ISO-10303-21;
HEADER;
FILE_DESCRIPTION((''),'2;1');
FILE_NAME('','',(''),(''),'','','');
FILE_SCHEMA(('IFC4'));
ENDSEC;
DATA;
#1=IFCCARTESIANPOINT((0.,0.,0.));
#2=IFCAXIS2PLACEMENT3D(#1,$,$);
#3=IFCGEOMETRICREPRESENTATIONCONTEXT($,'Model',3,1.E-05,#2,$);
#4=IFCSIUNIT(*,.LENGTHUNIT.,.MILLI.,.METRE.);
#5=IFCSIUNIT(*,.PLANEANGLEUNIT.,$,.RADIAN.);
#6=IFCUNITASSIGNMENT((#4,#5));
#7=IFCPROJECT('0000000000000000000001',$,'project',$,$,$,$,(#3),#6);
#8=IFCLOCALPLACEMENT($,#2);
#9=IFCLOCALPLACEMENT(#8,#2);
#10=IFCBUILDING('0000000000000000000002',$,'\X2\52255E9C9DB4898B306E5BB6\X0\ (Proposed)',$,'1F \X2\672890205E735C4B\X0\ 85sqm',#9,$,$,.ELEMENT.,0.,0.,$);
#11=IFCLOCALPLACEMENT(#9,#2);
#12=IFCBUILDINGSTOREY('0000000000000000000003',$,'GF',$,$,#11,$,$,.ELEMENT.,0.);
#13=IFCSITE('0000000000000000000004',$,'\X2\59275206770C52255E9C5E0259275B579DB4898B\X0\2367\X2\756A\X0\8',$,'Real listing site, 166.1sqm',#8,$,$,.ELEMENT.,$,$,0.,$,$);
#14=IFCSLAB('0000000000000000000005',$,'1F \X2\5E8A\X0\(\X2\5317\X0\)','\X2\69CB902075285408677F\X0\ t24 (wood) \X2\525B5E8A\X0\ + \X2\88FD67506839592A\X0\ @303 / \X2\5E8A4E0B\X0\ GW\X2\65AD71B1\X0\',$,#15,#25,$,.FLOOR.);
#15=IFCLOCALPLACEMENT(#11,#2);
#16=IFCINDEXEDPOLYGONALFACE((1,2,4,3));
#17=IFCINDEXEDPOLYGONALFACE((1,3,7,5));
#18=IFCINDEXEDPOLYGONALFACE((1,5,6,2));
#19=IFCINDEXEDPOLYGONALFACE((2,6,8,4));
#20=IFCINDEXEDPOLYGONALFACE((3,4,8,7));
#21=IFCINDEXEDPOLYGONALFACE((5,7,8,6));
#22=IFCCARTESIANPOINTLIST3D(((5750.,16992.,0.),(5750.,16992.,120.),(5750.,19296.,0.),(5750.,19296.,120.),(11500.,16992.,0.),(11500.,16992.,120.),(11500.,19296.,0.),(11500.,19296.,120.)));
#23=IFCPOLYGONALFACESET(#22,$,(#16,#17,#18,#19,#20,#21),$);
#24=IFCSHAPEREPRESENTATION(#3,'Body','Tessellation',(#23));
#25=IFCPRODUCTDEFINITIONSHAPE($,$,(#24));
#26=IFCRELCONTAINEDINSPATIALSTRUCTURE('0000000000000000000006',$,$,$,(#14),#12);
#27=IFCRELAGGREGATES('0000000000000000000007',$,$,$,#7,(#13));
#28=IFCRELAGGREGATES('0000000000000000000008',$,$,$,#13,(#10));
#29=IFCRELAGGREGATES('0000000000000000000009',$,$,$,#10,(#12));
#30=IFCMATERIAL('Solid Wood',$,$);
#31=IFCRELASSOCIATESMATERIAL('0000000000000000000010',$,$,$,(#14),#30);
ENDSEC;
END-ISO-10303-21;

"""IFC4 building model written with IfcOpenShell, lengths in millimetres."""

from ifc_helpers import new_model, si_unit, frame, frame_2d, origin, place, context, project, spatial, rectangle, extrude, material, element, save


model = new_model("IFC4")

# Units and contexts
model_context = context("Model", 3, precision=1e-05, world=origin())
ifc_project = project(units=[si_unit("LENGTHUNIT", "METRE", prefix="MILLI"), si_unit("PLANEANGLEUNIT", "RADIAN")], contexts=[model_context])

# Site, building, storey
site_placement = place(None, origin())
site = spatial("IfcSite", under=ifc_project, at=site_placement, Name="大分県別府市大字鶴見2367番8", ObjectType="Real listing site, 166.1sqm", CompositionType="ELEMENT", RefElevation=0.0)
building_placement = place(site_placement, origin())
building = spatial("IfcBuilding", under=site, at=building_placement, Name="別府鶴見の家 (Proposed)", ObjectType="1F 木造平屋 85sqm", CompositionType="ELEMENT", ElevationOfRefHeight=0.0, ElevationOfTerrain=0.0)
storey_placement = place(building_placement, origin())
storey = spatial("IfcBuildingStorey", under=building, at=storey_placement, Name="GF", CompositionType="ELEMENT", Elevation=0.0)

# Slab
ifc_material_1 = material(Name="Solid Wood")
slab_1_placement = place(storey_placement, frame((2875.0, 8496.0, 0.0)))
element("IfcSlab", 1, at=slab_1_placement, inside=storey, material=ifc_material_1, Name="1F 床(北)", Description="構造用合板 t24 (wood) 剛床 + 製材根太 @303 / 床下 GW断熱", PredefinedType="FLOOR", context=model_context, shape_type="SweptSolid", body=[
    extrude(rectangle(XDim=5750.0, YDim=2304.0, at=frame_2d((2875.0, 1152.0))), frame((2875.0, 8496.0, 0.0)), (0.0, 0.0, 1.0), 120.0),
])

save(model, "model.ifc")
